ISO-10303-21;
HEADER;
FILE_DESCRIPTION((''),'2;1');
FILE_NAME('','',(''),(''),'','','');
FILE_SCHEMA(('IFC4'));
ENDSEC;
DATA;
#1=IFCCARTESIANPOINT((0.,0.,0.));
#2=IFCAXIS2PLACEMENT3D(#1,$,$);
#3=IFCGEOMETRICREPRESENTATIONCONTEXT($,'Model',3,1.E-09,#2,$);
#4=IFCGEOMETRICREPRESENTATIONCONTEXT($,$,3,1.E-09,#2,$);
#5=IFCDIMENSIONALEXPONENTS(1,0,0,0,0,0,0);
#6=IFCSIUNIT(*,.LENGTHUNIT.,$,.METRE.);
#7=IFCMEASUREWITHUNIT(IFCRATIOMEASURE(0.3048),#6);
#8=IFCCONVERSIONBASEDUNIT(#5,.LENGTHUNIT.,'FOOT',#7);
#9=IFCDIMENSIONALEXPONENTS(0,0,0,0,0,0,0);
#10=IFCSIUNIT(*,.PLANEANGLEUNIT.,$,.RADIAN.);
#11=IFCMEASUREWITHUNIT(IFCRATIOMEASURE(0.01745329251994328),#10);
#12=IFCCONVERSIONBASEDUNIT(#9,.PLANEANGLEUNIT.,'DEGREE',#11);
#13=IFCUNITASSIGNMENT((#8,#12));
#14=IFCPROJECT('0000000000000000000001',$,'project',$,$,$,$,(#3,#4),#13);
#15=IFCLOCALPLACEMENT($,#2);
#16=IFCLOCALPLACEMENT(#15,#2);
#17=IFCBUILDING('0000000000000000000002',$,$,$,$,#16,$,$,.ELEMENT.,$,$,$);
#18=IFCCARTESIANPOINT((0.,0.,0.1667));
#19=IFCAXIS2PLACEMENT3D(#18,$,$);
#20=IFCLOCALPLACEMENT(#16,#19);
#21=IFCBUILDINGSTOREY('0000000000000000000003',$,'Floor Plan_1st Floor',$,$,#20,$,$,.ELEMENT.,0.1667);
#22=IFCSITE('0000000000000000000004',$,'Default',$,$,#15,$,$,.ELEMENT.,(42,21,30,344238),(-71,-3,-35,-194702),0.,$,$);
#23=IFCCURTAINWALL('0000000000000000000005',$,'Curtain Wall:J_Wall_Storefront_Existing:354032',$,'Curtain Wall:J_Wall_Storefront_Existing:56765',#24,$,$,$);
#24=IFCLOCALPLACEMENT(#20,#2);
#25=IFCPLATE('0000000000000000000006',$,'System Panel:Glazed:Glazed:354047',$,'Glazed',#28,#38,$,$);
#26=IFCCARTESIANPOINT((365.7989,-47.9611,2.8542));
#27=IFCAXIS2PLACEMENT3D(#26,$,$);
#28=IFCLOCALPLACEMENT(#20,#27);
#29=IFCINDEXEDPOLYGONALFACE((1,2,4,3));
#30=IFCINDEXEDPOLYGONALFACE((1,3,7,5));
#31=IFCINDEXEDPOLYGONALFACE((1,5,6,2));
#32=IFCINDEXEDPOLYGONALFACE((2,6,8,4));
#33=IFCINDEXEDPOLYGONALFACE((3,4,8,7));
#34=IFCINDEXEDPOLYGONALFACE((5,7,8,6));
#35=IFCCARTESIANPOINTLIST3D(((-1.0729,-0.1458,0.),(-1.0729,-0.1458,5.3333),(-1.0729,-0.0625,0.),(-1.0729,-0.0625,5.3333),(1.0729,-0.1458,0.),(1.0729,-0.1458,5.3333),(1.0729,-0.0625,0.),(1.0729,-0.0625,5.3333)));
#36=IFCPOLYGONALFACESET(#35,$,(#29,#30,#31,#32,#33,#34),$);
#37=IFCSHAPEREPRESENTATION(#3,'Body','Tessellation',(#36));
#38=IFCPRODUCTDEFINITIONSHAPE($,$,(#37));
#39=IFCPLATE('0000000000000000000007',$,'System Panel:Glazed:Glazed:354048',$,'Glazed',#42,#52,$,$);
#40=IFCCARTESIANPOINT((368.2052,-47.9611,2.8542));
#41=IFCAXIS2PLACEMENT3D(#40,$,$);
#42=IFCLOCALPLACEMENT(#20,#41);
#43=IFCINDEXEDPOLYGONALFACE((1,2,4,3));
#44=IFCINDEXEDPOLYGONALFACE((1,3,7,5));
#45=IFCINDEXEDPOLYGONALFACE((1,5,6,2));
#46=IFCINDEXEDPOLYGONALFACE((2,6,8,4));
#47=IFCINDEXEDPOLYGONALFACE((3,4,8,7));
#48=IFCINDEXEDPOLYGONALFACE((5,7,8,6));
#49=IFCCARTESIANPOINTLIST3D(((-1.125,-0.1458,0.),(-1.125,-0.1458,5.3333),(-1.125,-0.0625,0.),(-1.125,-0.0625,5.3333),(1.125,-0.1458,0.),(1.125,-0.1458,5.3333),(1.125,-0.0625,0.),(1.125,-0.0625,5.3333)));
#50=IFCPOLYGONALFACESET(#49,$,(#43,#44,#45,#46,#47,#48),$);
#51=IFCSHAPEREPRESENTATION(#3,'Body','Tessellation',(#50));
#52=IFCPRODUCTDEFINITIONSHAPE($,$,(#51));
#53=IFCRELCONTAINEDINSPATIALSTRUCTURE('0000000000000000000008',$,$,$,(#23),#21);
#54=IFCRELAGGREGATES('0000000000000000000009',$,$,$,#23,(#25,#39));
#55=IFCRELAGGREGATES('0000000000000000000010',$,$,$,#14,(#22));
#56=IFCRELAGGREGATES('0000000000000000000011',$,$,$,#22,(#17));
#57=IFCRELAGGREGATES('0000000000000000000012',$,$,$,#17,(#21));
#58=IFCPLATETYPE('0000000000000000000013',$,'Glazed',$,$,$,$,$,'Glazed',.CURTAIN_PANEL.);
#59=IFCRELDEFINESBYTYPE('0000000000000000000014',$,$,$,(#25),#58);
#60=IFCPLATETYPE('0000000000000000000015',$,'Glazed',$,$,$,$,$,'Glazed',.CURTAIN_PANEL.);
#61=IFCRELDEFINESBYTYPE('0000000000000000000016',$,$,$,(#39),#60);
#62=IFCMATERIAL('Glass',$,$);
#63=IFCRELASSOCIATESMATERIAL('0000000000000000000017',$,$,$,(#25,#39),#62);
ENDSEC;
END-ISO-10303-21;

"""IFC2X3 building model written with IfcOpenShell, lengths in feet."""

from ifc_helpers import new_model, entity, si_unit, converted_unit, frame, origin, origin_2d_with_axis, place, context, project, spatial, rectangle, extrude, source, transform, mapped, material, type_object, type_shapes, element, aggregate, save


model = new_model("IFC2X3")

# Units and contexts
model_context = context("Model", 3, precision=1e-09, world=origin())
context_of_model = context(None, 3, precision=1e-09, world=origin())
ifc_project = project(units=[converted_unit("LENGTHUNIT", "FOOT", entity("IfcRatioMeasure", 0.3048), si_unit("LENGTHUNIT", "METRE"), dimensions=[1, 0, 0, 0, 0, 0, 0]), converted_unit("PLANEANGLEUNIT", "DEGREE", entity("IfcRatioMeasure", 0.01745329251994328), si_unit("PLANEANGLEUNIT", "RADIAN"), dimensions=[0, 0, 0, 0, 0, 0, 0])], contexts=[model_context, context_of_model])

# Site, building, storey
site_placement = place(None, origin())
site = spatial("IfcSite", under=ifc_project, at=site_placement, Name="Default", CompositionType="ELEMENT", RefLatitude=(42, 21, 30, 344238), RefLongitude=(-71, -3, -35, -194702), RefElevation=0.0)
building_placement = place(site_placement, origin())
building = spatial("IfcBuilding", under=site, at=building_placement, CompositionType="ELEMENT")
storey_placement = place(building_placement, frame((0.0, 0.0, 0.1667)))
storey = spatial("IfcBuildingStorey", under=building, at=storey_placement, Name="Floor Plan_1st Floor", CompositionType="ELEMENT", Elevation=0.1667)

# Curtain wall
curtain_wall_1_placement = place(storey_placement, origin())
curtain_wall_1 = element("IfcCurtainWall", 1, at=curtain_wall_1_placement, inside=storey, Name="Curtain Wall:J_Wall_Storefront_Existing:354032", ObjectType="Curtain Wall:J_Wall_Storefront_Existing:56765")

# Plates
ifc_material_1 = material(Name="Glass")
plate_type_1 = type_object("IfcPlateType", Name="Glazed", ElementType="Glazed", PredefinedType="CURTAIN_PANEL")
shared_shape_1 = source(origin(), model_context, "Body", "SweptSolid", [
    extrude(rectangle(XDim=0.0833, YDim=2.1458, at=origin_2d_with_axis()), frame((0.0, -0.1042, 0.0), z_axis=(0.0, 0.0, 1.0), x_axis=(0.0, 1.0, 0.0)), (0.0, 0.0, 1.0), 5.3333),
])
type_shapes(plate_type_1, [shared_shape_1])
plate_1_placement = place(storey_placement, frame((365.7989, -47.9611, 2.8542)))
plate_1 = element("IfcPlate", 2, at=plate_1_placement, type_object=plate_type_1, material=ifc_material_1, Name="System Panel:Glazed:Glazed:354047", ObjectType="Glazed", context=model_context, shape_type="MappedRepresentation", body=[
    mapped(shared_shape_1, transform((0.0, 0.0, 0.0), scale=1.0)),
])
plate_type_2 = type_object("IfcPlateType", Name="Glazed", ElementType="Glazed", PredefinedType="CURTAIN_PANEL")
shared_shape_2 = source(origin(), model_context, "Body", "SweptSolid", [
    extrude(rectangle(XDim=0.0833, YDim=2.25, at=origin_2d_with_axis()), frame((0.0, -0.1042, 0.0), z_axis=(0.0, 0.0, 1.0), x_axis=(0.0, 1.0, 0.0)), (0.0, 0.0, 1.0), 5.3333),
])
type_shapes(plate_type_2, [shared_shape_2])
plate_2_placement = place(storey_placement, frame((368.2052, -47.9611, 2.8542)))
plate_2 = element("IfcPlate", 3, at=plate_2_placement, type_object=plate_type_2, material=ifc_material_1, Name="System Panel:Glazed:Glazed:354048", ObjectType="Glazed", context=model_context, shape_type="MappedRepresentation", body=[
    mapped(shared_shape_2, transform((0.0, 0.0, 0.0), scale=1.0)),
])
aggregate(curtain_wall_1, [plate_1, plate_2])

save(model, "model.ifc")
